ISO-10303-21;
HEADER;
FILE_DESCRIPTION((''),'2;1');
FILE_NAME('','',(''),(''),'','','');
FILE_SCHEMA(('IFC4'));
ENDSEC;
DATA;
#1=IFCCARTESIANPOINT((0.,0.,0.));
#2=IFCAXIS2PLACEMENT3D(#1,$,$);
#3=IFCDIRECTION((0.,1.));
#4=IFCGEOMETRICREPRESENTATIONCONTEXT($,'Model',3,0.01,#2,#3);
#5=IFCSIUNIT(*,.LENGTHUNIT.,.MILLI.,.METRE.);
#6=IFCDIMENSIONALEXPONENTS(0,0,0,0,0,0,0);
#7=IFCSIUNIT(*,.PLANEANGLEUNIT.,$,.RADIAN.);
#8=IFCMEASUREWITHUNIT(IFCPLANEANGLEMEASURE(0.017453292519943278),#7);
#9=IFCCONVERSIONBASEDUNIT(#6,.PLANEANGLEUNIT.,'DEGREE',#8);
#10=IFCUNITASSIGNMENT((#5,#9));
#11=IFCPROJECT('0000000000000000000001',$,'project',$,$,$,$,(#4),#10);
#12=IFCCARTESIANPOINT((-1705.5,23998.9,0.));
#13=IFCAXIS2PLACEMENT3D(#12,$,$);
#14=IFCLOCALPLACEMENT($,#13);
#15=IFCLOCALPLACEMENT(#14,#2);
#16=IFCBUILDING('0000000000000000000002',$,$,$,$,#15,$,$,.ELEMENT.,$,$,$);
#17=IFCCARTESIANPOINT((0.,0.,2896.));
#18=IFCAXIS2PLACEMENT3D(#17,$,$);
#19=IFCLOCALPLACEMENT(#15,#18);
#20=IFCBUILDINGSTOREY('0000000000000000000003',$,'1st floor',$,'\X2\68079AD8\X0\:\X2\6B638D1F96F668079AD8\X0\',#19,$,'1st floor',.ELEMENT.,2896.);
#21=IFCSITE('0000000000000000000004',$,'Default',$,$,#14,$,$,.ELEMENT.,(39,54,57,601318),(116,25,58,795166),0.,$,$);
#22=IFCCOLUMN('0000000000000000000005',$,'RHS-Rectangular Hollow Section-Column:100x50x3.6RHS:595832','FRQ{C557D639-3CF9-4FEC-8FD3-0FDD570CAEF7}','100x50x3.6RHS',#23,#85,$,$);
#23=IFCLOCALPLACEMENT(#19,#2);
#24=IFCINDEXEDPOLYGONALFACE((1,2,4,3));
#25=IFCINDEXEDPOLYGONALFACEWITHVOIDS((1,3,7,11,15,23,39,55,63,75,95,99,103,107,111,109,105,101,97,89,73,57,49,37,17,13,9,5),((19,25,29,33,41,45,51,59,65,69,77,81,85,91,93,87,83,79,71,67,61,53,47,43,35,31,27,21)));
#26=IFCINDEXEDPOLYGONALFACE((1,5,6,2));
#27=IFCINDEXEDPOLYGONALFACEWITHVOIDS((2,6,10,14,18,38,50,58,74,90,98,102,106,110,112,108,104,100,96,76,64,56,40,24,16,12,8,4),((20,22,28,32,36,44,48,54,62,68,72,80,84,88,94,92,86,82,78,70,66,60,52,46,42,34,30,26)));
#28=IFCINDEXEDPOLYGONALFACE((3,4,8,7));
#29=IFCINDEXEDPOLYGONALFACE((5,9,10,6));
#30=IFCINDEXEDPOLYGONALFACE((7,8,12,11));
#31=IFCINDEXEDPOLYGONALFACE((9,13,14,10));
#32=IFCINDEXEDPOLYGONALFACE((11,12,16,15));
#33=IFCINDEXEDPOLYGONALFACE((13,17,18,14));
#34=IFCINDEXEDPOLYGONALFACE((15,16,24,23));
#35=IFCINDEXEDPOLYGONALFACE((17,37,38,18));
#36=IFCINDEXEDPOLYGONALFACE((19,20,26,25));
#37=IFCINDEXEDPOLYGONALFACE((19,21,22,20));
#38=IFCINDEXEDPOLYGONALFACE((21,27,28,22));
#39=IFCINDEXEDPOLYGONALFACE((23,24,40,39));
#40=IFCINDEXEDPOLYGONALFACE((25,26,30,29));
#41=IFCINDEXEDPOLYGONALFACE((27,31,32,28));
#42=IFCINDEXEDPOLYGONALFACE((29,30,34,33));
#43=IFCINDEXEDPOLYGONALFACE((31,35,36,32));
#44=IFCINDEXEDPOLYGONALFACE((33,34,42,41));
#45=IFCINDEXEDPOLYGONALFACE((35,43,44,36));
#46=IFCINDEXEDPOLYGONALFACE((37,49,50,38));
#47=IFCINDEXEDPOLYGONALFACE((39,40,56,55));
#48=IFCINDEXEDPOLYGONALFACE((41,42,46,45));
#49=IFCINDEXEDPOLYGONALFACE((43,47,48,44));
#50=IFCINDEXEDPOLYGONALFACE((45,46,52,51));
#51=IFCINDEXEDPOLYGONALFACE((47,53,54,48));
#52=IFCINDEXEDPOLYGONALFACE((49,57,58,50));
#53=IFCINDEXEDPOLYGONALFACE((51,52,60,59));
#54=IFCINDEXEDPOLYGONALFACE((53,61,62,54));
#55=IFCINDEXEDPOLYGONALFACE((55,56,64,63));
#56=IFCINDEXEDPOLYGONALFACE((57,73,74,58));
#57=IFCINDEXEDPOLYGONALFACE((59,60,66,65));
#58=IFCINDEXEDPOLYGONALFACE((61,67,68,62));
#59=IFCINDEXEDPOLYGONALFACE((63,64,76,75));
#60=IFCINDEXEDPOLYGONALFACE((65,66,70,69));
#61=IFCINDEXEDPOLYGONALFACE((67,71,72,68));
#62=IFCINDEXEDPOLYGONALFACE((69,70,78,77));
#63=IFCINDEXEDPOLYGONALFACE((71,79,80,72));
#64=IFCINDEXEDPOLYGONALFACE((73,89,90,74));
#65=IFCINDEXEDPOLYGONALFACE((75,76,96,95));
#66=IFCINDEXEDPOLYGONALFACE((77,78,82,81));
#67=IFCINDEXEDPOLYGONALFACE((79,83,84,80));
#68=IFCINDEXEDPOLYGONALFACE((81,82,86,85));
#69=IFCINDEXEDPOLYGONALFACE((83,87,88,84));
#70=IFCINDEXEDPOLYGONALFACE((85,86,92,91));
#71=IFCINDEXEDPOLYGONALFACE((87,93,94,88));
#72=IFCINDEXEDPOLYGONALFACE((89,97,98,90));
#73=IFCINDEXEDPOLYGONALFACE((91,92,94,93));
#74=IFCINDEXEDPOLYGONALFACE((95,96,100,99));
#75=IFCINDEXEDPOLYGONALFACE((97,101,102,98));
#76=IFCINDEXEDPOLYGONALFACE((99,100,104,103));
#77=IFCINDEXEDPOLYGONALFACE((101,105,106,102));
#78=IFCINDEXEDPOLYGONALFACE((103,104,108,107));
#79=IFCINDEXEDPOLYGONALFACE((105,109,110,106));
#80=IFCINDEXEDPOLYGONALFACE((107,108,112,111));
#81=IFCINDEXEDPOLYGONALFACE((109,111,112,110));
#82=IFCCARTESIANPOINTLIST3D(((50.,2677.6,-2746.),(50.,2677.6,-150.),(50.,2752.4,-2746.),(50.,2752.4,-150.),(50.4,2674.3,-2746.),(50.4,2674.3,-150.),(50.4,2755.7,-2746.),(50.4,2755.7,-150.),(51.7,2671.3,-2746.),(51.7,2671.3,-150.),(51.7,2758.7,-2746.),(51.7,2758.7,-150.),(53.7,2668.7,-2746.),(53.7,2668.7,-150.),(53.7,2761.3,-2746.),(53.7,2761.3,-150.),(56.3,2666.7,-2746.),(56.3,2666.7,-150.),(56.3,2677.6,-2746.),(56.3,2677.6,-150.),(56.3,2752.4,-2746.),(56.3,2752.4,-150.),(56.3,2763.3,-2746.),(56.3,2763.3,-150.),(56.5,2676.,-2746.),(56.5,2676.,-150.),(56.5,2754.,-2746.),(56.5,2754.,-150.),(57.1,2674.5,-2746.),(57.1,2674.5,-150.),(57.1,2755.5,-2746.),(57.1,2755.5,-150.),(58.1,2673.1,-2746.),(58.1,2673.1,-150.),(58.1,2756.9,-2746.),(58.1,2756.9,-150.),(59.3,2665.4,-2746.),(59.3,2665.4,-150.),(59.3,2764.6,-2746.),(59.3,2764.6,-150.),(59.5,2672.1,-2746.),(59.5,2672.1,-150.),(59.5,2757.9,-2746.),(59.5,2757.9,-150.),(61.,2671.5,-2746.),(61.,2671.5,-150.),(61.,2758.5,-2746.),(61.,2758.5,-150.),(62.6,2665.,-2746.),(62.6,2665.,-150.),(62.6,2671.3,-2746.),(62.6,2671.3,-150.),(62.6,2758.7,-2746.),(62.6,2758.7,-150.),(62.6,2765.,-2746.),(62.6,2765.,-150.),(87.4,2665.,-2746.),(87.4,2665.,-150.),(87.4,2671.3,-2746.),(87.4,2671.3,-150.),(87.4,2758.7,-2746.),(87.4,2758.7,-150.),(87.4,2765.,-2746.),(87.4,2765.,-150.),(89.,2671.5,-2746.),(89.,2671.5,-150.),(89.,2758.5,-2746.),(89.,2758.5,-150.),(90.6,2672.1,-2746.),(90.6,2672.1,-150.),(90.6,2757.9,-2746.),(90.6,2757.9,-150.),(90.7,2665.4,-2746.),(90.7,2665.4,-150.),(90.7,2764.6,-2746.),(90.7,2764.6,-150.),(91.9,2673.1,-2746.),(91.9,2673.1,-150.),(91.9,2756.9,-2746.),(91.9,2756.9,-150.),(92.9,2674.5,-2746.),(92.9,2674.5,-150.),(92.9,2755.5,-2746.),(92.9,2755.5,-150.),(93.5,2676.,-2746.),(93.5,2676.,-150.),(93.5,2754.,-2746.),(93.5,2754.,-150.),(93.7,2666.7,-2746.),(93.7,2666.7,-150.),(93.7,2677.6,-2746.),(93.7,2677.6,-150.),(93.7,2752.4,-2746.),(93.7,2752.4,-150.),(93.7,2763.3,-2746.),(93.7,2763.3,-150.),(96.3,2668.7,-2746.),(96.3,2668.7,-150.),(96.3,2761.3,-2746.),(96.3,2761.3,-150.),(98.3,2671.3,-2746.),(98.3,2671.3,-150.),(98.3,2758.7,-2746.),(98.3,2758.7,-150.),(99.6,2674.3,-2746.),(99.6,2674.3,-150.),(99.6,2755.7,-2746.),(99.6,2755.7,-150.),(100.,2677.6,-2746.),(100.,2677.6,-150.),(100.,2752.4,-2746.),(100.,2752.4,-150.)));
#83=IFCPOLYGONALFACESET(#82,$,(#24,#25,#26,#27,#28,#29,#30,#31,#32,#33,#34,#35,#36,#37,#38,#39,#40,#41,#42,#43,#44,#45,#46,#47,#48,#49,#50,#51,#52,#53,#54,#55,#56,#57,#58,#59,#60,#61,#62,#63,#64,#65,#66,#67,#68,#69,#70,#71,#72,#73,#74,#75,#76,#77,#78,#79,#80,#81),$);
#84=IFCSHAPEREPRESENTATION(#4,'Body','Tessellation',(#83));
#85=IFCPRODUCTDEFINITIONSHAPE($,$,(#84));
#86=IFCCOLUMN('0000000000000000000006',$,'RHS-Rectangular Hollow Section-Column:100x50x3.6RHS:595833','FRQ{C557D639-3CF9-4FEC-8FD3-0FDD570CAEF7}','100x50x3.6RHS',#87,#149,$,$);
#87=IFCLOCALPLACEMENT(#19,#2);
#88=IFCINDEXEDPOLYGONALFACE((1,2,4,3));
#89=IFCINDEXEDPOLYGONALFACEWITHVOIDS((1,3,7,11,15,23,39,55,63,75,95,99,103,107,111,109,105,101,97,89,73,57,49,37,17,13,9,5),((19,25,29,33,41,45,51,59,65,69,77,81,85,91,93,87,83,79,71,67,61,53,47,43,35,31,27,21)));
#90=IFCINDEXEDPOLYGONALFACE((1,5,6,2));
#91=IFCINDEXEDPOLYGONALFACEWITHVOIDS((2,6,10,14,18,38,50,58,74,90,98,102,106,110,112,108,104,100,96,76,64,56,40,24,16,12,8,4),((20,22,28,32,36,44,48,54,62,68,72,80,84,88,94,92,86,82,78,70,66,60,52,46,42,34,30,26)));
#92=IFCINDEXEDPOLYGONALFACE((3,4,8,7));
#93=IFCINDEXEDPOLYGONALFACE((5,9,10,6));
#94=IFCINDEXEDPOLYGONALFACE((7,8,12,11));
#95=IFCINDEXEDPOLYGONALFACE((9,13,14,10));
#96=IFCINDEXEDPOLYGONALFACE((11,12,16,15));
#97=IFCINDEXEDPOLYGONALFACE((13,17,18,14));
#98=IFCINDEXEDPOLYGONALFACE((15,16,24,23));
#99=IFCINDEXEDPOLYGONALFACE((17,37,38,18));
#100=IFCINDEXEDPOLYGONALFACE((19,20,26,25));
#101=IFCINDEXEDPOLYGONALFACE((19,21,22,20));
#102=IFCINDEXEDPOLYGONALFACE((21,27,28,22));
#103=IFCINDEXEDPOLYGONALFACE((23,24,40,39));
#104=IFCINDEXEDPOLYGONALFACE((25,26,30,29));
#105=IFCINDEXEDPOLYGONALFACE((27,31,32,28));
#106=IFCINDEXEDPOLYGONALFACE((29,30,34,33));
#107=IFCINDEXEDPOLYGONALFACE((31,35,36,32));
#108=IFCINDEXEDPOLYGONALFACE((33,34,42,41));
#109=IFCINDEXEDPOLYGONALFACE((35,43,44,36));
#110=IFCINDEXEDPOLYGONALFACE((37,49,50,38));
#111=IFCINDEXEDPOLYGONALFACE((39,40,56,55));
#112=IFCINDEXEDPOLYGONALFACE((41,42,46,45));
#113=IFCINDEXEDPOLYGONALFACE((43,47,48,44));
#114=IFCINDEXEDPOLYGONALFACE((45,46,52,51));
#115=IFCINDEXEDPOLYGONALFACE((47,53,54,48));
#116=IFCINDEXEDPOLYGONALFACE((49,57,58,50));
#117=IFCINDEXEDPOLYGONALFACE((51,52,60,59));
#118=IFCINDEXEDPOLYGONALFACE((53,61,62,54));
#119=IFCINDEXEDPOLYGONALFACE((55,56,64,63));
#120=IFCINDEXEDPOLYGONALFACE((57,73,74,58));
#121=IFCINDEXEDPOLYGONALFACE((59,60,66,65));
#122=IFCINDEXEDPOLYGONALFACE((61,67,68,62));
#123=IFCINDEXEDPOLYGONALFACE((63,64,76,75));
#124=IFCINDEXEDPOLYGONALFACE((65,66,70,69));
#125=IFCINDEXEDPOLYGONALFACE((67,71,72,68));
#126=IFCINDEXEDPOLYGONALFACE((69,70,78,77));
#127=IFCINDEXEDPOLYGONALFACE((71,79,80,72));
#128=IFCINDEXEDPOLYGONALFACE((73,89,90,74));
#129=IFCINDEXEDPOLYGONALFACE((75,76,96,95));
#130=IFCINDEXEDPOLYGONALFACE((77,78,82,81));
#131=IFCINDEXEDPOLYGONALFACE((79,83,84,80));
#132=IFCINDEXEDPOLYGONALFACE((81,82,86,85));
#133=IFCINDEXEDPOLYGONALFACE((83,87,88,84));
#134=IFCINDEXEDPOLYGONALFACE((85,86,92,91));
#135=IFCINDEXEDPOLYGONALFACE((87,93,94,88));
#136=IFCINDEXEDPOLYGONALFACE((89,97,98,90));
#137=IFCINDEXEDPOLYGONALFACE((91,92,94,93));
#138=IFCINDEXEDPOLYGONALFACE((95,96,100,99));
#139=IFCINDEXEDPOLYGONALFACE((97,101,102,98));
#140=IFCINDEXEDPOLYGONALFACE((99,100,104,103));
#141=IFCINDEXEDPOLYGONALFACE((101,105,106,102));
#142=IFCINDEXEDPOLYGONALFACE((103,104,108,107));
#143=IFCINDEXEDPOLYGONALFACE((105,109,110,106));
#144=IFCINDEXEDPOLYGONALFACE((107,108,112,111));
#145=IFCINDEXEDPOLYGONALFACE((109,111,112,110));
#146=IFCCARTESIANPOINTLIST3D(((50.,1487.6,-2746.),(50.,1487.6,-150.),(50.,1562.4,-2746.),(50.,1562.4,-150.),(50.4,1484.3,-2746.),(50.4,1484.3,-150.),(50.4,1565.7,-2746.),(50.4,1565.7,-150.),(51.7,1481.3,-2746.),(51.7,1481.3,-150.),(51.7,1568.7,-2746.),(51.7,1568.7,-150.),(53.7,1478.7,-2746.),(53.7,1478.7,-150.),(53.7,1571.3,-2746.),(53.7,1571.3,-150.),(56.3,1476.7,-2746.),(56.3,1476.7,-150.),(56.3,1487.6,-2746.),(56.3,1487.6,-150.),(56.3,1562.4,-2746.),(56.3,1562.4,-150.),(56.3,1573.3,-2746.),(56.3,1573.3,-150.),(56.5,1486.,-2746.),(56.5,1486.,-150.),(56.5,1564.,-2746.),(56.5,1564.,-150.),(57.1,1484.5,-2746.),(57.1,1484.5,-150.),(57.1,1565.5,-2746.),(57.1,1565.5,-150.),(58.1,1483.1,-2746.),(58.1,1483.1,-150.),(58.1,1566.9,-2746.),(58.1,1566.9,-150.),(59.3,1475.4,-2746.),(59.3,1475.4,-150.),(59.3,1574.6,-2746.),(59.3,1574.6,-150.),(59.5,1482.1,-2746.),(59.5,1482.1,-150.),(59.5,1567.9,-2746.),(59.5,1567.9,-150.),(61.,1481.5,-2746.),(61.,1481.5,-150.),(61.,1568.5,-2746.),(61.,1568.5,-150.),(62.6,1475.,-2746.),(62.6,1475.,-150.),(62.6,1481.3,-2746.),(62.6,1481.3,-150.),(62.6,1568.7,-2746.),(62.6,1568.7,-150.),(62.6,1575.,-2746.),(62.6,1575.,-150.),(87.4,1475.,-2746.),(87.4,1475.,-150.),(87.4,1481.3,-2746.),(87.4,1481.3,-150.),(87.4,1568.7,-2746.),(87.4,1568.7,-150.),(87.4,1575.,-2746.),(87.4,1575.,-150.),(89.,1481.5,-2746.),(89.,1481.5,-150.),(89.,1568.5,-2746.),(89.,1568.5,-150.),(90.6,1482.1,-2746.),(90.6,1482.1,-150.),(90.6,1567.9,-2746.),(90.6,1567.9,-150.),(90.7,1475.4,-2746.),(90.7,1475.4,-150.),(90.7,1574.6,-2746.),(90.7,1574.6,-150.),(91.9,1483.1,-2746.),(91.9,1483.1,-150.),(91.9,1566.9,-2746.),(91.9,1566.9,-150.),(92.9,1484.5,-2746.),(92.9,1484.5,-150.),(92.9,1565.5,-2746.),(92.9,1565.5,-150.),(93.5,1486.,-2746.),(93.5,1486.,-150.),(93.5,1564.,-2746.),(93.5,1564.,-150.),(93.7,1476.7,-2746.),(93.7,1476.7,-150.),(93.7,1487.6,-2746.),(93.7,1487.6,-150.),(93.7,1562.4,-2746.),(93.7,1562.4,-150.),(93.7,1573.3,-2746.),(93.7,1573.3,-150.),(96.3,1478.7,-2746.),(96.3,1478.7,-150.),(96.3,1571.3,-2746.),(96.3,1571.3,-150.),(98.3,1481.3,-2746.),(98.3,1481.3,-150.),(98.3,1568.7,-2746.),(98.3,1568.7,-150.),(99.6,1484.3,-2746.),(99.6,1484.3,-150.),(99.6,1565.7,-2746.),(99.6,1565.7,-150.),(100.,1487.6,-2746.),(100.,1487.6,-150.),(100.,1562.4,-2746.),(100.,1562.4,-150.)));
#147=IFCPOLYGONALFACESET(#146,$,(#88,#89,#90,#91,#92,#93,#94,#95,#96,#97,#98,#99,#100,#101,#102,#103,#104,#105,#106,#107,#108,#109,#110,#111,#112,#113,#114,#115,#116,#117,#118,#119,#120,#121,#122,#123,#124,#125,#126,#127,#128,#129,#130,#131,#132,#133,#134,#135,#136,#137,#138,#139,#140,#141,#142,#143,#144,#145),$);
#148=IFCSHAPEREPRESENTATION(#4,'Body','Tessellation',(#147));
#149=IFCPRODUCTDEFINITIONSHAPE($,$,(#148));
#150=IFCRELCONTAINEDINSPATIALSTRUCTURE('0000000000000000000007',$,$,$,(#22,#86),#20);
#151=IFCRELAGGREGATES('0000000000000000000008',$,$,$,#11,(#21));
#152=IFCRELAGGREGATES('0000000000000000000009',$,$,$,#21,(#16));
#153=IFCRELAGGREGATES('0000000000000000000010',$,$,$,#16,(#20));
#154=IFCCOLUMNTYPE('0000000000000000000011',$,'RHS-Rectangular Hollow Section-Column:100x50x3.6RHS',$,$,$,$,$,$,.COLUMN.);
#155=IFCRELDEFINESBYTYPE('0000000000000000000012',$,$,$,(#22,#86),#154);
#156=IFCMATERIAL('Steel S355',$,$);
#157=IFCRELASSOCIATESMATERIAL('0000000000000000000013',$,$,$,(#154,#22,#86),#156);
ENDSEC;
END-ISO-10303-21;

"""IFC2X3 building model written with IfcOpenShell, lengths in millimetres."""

from ifc_helpers import new_model, entity, si_unit, converted_unit, direction, frame, origin, origin_2d, place, context, project, spatial, hollow_rectangle, extrude, clip, halfspace, material, type_object, element, save


model = new_model("IFC2X3")

# Units and contexts
model_context = context("Model", 3, precision=0.01, world=origin(), true_north=direction((0.0, 1.0)))
ifc_project = project(units=[si_unit("LENGTHUNIT", "METRE", prefix="MILLI"), converted_unit("PLANEANGLEUNIT", "DEGREE", entity("IfcPlaneAngleMeasure", 0.017453292519943278), si_unit("PLANEANGLEUNIT", "RADIAN"), dimensions=[0, 0, 0, 0, 0, 0, 0])], contexts=[model_context])

# Site, building, storey
site_placement = place(None, frame((-1705.5, 23998.9, 0.0)))
site = spatial("IfcSite", under=ifc_project, at=site_placement, Name="Default", CompositionType="ELEMENT", RefLatitude=(39, 54, 57, 601318), RefLongitude=(116, 25, 58, 795166), RefElevation=0.0)
building_placement = place(site_placement, origin())
building = spatial("IfcBuilding", under=site, at=building_placement, CompositionType="ELEMENT")
storey_placement = place(building_placement, frame((0.0, 0.0, 2896.0)))
storey = spatial("IfcBuildingStorey", under=building, at=storey_placement, Name="1st floor", ObjectType="标高:正负零标高", LongName="1st floor", CompositionType="ELEMENT", Elevation=2896.0)

# Shared definitions
ifc_material_1 = material(Name="Steel S355")

# Columns
column_type_1 = type_object("IfcColumnType", Name="RHS-Rectangular Hollow Section-Column:100x50x3.6RHS", PredefinedType="COLUMN", material=ifc_material_1)
column_1_placement = place(storey_placement, frame((75.0, 2715.0, -150.0), z_axis=(0.0, 0.0, 1.0), x_axis=(-1.0, 0.0, 0.0)))
element("IfcColumn", 1, at=column_1_placement, inside=storey, type_object=column_type_1, material=ifc_material_1, Name="RHS-Rectangular Hollow Section-Column:100x50x3.6RHS:595832", Description="FRQ{C557D639-3CF9-4FEC-8FD3-0FDD570CAEF7}", ObjectType="100x50x3.6RHS", context=model_context, shape_type="Clipping", body=[
    clip(extrude(hollow_rectangle(XDim=50.0, YDim=100.0, WallThickness=6.3, InnerFilletRadius=6.3, OuterFilletRadius=12.6, at=origin_2d()), origin(), (0.0, 0.0, -1.0), 2651.9), halfspace(frame((75.0, 2715.0, -2596.0), z_axis=(0.0, 0.0, 1.0), x_axis=(-1.0, 0.0, 0.0)), True)),
])
column_2_placement = place(storey_placement, frame((75.0, 1525.0, -150.0), z_axis=(0.0, 0.0, 1.0), x_axis=(-1.0, 0.0, 0.0)))
element("IfcColumn", 2, at=column_2_placement, inside=storey, type_object=column_type_1, material=ifc_material_1, Name="RHS-Rectangular Hollow Section-Column:100x50x3.6RHS:595833", Description="FRQ{C557D639-3CF9-4FEC-8FD3-0FDD570CAEF7}", ObjectType="100x50x3.6RHS", context=model_context, shape_type="Clipping", body=[
    clip(extrude(hollow_rectangle(XDim=50.0, YDim=100.0, WallThickness=6.3, InnerFilletRadius=6.3, OuterFilletRadius=12.6, at=origin_2d()), origin(), (0.0, 0.0, -1.0), 2651.9), halfspace(frame((75.0, 1525.0, -2596.0), z_axis=(0.0, 0.0, 1.0), x_axis=(-1.0, 0.0, 0.0)), True)),
])

save(model, "model.ifc")
